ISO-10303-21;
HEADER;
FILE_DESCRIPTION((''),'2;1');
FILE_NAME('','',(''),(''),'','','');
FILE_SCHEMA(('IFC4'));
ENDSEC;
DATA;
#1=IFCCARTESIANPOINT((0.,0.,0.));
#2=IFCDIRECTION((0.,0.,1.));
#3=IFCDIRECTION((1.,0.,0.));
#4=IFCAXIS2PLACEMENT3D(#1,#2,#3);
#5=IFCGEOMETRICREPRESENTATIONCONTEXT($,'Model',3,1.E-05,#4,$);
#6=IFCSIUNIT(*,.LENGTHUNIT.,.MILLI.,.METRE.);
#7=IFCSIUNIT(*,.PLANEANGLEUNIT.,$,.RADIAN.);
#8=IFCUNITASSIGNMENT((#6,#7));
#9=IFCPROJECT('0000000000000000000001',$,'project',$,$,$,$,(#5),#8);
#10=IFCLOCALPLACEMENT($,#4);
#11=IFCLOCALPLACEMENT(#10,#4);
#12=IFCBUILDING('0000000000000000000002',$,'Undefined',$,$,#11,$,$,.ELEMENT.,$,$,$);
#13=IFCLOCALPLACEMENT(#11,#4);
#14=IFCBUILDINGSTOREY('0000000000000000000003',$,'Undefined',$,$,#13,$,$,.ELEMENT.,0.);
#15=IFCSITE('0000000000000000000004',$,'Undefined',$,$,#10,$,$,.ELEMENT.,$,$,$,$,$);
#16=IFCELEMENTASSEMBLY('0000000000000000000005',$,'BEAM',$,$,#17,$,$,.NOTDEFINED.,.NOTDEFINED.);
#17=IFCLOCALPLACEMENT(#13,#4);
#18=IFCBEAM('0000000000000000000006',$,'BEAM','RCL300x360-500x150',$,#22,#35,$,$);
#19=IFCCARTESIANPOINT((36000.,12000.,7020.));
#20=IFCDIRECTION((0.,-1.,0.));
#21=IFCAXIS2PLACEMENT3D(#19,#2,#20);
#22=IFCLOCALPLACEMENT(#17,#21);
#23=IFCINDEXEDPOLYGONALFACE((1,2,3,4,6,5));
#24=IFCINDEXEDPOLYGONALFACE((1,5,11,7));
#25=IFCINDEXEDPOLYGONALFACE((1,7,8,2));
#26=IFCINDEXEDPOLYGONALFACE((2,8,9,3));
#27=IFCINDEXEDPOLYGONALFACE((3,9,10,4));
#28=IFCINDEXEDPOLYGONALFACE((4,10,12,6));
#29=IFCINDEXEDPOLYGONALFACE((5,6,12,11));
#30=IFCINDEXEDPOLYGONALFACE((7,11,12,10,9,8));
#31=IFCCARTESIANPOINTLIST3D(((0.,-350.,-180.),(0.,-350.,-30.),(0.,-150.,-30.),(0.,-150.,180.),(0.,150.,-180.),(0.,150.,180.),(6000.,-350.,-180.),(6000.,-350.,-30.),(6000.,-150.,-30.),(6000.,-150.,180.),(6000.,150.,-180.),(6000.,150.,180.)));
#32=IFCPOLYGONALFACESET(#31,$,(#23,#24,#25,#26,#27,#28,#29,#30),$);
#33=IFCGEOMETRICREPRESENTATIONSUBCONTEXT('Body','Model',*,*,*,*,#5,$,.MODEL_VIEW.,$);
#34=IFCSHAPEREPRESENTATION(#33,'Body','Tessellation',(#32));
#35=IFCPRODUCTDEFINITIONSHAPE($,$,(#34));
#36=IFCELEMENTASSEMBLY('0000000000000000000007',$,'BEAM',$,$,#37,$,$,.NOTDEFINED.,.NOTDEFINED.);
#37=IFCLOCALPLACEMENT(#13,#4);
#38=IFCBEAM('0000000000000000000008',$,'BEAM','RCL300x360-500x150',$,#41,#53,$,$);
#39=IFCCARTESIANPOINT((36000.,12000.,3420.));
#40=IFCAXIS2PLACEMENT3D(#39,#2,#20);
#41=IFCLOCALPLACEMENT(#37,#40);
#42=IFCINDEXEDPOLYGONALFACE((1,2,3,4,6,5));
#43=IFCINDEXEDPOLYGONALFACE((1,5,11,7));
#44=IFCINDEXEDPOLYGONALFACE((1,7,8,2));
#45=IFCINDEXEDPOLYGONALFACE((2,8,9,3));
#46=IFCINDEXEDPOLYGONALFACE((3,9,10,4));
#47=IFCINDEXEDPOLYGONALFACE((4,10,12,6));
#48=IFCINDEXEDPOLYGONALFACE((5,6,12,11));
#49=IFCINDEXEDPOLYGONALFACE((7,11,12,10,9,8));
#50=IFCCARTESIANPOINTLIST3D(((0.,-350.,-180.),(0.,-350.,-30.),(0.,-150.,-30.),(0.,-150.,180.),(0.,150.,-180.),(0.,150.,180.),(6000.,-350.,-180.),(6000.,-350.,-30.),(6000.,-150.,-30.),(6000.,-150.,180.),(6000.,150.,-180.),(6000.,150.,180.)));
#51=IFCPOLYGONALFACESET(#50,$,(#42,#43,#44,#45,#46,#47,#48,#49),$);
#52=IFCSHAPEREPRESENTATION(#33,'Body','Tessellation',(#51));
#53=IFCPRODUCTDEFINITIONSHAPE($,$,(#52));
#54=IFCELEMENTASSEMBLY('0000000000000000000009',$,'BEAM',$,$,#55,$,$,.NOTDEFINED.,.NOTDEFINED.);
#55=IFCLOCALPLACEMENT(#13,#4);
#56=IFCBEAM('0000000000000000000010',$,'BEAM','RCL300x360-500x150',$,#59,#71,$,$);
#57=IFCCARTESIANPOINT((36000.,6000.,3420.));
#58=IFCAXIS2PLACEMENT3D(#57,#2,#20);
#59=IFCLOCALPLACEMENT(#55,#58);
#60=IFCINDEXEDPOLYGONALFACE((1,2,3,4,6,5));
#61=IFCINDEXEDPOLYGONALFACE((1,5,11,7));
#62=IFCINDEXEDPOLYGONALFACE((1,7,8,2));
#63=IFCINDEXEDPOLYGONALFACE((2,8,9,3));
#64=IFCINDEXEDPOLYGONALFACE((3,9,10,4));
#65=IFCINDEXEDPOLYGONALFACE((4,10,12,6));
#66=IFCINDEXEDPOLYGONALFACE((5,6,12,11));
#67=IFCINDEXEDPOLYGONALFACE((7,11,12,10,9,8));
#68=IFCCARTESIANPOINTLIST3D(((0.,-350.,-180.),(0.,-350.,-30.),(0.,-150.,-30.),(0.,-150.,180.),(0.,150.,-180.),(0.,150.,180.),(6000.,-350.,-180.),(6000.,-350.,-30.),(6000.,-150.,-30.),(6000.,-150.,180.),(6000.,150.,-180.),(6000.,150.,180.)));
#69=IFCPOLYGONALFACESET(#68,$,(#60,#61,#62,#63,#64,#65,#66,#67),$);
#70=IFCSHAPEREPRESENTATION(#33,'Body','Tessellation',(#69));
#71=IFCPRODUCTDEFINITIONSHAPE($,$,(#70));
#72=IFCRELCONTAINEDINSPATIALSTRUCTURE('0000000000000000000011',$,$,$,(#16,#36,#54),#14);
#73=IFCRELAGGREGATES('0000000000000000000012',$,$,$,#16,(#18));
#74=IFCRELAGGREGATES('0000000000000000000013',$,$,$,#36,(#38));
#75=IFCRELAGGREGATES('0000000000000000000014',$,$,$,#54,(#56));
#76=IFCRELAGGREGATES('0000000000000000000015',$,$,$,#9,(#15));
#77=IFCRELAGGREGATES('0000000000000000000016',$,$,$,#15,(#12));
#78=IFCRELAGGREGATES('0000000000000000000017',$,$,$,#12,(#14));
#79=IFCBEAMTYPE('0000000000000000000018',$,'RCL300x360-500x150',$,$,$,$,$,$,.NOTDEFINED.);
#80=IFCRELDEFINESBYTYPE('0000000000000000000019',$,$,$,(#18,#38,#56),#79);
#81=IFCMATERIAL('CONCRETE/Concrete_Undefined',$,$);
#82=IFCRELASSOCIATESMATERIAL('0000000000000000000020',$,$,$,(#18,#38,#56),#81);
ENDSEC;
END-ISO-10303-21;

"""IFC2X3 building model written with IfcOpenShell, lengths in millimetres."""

from ifc_helpers import new_model, si_unit, frame, origin_with_axes, place, context, subcontext, project, spatial, polyline, outline, extrude, material, type_object, element, aggregate, save


model = new_model("IFC2X3")

# Units and contexts
model_context = context("Model", 3, precision=1e-05, world=origin_with_axes())
body_context = subcontext(model_context, "Body", "Model", "MODEL_VIEW")
ifc_project = project(units=[si_unit("LENGTHUNIT", "METRE", prefix="MILLI"), si_unit("PLANEANGLEUNIT", "RADIAN")], contexts=[model_context])

# Site, building, storey
site_placement = place(None, origin_with_axes())
site = spatial("IfcSite", under=ifc_project, at=site_placement, Name="Undefined", CompositionType="ELEMENT")
building_placement = place(site_placement, origin_with_axes())
building = spatial("IfcBuilding", under=site, at=building_placement, Name="Undefined", CompositionType="ELEMENT")
storey_placement = place(building_placement, origin_with_axes())
storey = spatial("IfcBuildingStorey", under=building, at=storey_placement, Name="Undefined", CompositionType="ELEMENT", Elevation=0.0)

# Shared definitions
ifc_material = material(Name="CONCRETE/Concrete_Undefined")

# Element assemblies, beams
assembly_1_placement = place(storey_placement, origin_with_axes())
assembly_1 = element("IfcElementAssembly", 1, at=assembly_1_placement, inside=storey, Name="BEAM", AssemblyPlace="NOTDEFINED", PredefinedType="NOTDEFINED")
beam_type = type_object("IfcBeamType", Name="RCL300x360-500x150", PredefinedType="NOTDEFINED")
beam_1_placement = place(assembly_1_placement, frame((36000.0, 12000.0, 7020.0), z_axis=(0.0, 0.0, 1.0), x_axis=(0.0, -1.0, 0.0)))
beam_1 = element("IfcBeam", 2, at=beam_1_placement, type_object=beam_type, material=ifc_material, Name="BEAM", Description="RCL300x360-500x150", context=body_context, shape_type="SweptSolid", body=[
    extrude(outline(polyline([(350.0, -180.0), (-150.0, -180.0), (-150.0, 180.0), (150.0, 180.0), (150.0, -30.0), (350.0, -30.0), (350.0, -180.0)])), frame((6000.0, 0.0, 0.0), z_axis=(-1.0, 0.0, 0.0), x_axis=(0.0, -1.0, 0.0)), (0.0, 0.0, 1.0), 6000.0),
])
aggregate(assembly_1, [beam_1])
assembly_2_placement = place(storey_placement, origin_with_axes())
assembly_2 = element("IfcElementAssembly", 3, at=assembly_2_placement, inside=storey, Name="BEAM", AssemblyPlace="NOTDEFINED", PredefinedType="NOTDEFINED")
beam_2_placement = place(assembly_2_placement, frame((36000.0, 12000.0, 3420.0), z_axis=(0.0, 0.0, 1.0), x_axis=(0.0, -1.0, 0.0)))
beam_2 = element("IfcBeam", 4, at=beam_2_placement, type_object=beam_type, material=ifc_material, Name="BEAM", Description="RCL300x360-500x150", context=body_context, shape_type="SweptSolid", body=[
    extrude(outline(polyline([(350.0, -180.0), (-150.0, -180.0), (-150.0, 180.0), (150.0, 180.0), (150.0, -30.0), (350.0, -30.0), (350.0, -180.0)])), frame((6000.0, 0.0, 0.0), z_axis=(-1.0, 0.0, 0.0), x_axis=(0.0, -1.0, 0.0)), (0.0, 0.0, 1.0), 6000.0),
])
aggregate(assembly_2, [beam_2])
assembly_3_placement = place(storey_placement, origin_with_axes())
assembly_3 = element("IfcElementAssembly", 5, at=assembly_3_placement, inside=storey, Name="BEAM", AssemblyPlace="NOTDEFINED", PredefinedType="NOTDEFINED")
beam_3_placement = place(assembly_3_placement, frame((36000.0, 6000.0, 3420.0), z_axis=(0.0, 0.0, 1.0), x_axis=(0.0, -1.0, 0.0)))
beam_3 = element("IfcBeam", 6, at=beam_3_placement, type_object=beam_type, material=ifc_material, Name="BEAM", Description="RCL300x360-500x150", context=body_context, shape_type="SweptSolid", body=[
    extrude(outline(polyline([(350.0, -180.0), (-150.0, -180.0), (-150.0, 180.0), (150.0, 180.0), (150.0, -30.0), (350.0, -30.0), (350.0, -180.0)])), frame((6000.0, 0.0, 0.0), z_axis=(-1.0, 0.0, 0.0), x_axis=(0.0, -1.0, 0.0)), (0.0, 0.0, 1.0), 6000.0),
])
aggregate(assembly_3, [beam_3])

save(model, "model.ifc")
